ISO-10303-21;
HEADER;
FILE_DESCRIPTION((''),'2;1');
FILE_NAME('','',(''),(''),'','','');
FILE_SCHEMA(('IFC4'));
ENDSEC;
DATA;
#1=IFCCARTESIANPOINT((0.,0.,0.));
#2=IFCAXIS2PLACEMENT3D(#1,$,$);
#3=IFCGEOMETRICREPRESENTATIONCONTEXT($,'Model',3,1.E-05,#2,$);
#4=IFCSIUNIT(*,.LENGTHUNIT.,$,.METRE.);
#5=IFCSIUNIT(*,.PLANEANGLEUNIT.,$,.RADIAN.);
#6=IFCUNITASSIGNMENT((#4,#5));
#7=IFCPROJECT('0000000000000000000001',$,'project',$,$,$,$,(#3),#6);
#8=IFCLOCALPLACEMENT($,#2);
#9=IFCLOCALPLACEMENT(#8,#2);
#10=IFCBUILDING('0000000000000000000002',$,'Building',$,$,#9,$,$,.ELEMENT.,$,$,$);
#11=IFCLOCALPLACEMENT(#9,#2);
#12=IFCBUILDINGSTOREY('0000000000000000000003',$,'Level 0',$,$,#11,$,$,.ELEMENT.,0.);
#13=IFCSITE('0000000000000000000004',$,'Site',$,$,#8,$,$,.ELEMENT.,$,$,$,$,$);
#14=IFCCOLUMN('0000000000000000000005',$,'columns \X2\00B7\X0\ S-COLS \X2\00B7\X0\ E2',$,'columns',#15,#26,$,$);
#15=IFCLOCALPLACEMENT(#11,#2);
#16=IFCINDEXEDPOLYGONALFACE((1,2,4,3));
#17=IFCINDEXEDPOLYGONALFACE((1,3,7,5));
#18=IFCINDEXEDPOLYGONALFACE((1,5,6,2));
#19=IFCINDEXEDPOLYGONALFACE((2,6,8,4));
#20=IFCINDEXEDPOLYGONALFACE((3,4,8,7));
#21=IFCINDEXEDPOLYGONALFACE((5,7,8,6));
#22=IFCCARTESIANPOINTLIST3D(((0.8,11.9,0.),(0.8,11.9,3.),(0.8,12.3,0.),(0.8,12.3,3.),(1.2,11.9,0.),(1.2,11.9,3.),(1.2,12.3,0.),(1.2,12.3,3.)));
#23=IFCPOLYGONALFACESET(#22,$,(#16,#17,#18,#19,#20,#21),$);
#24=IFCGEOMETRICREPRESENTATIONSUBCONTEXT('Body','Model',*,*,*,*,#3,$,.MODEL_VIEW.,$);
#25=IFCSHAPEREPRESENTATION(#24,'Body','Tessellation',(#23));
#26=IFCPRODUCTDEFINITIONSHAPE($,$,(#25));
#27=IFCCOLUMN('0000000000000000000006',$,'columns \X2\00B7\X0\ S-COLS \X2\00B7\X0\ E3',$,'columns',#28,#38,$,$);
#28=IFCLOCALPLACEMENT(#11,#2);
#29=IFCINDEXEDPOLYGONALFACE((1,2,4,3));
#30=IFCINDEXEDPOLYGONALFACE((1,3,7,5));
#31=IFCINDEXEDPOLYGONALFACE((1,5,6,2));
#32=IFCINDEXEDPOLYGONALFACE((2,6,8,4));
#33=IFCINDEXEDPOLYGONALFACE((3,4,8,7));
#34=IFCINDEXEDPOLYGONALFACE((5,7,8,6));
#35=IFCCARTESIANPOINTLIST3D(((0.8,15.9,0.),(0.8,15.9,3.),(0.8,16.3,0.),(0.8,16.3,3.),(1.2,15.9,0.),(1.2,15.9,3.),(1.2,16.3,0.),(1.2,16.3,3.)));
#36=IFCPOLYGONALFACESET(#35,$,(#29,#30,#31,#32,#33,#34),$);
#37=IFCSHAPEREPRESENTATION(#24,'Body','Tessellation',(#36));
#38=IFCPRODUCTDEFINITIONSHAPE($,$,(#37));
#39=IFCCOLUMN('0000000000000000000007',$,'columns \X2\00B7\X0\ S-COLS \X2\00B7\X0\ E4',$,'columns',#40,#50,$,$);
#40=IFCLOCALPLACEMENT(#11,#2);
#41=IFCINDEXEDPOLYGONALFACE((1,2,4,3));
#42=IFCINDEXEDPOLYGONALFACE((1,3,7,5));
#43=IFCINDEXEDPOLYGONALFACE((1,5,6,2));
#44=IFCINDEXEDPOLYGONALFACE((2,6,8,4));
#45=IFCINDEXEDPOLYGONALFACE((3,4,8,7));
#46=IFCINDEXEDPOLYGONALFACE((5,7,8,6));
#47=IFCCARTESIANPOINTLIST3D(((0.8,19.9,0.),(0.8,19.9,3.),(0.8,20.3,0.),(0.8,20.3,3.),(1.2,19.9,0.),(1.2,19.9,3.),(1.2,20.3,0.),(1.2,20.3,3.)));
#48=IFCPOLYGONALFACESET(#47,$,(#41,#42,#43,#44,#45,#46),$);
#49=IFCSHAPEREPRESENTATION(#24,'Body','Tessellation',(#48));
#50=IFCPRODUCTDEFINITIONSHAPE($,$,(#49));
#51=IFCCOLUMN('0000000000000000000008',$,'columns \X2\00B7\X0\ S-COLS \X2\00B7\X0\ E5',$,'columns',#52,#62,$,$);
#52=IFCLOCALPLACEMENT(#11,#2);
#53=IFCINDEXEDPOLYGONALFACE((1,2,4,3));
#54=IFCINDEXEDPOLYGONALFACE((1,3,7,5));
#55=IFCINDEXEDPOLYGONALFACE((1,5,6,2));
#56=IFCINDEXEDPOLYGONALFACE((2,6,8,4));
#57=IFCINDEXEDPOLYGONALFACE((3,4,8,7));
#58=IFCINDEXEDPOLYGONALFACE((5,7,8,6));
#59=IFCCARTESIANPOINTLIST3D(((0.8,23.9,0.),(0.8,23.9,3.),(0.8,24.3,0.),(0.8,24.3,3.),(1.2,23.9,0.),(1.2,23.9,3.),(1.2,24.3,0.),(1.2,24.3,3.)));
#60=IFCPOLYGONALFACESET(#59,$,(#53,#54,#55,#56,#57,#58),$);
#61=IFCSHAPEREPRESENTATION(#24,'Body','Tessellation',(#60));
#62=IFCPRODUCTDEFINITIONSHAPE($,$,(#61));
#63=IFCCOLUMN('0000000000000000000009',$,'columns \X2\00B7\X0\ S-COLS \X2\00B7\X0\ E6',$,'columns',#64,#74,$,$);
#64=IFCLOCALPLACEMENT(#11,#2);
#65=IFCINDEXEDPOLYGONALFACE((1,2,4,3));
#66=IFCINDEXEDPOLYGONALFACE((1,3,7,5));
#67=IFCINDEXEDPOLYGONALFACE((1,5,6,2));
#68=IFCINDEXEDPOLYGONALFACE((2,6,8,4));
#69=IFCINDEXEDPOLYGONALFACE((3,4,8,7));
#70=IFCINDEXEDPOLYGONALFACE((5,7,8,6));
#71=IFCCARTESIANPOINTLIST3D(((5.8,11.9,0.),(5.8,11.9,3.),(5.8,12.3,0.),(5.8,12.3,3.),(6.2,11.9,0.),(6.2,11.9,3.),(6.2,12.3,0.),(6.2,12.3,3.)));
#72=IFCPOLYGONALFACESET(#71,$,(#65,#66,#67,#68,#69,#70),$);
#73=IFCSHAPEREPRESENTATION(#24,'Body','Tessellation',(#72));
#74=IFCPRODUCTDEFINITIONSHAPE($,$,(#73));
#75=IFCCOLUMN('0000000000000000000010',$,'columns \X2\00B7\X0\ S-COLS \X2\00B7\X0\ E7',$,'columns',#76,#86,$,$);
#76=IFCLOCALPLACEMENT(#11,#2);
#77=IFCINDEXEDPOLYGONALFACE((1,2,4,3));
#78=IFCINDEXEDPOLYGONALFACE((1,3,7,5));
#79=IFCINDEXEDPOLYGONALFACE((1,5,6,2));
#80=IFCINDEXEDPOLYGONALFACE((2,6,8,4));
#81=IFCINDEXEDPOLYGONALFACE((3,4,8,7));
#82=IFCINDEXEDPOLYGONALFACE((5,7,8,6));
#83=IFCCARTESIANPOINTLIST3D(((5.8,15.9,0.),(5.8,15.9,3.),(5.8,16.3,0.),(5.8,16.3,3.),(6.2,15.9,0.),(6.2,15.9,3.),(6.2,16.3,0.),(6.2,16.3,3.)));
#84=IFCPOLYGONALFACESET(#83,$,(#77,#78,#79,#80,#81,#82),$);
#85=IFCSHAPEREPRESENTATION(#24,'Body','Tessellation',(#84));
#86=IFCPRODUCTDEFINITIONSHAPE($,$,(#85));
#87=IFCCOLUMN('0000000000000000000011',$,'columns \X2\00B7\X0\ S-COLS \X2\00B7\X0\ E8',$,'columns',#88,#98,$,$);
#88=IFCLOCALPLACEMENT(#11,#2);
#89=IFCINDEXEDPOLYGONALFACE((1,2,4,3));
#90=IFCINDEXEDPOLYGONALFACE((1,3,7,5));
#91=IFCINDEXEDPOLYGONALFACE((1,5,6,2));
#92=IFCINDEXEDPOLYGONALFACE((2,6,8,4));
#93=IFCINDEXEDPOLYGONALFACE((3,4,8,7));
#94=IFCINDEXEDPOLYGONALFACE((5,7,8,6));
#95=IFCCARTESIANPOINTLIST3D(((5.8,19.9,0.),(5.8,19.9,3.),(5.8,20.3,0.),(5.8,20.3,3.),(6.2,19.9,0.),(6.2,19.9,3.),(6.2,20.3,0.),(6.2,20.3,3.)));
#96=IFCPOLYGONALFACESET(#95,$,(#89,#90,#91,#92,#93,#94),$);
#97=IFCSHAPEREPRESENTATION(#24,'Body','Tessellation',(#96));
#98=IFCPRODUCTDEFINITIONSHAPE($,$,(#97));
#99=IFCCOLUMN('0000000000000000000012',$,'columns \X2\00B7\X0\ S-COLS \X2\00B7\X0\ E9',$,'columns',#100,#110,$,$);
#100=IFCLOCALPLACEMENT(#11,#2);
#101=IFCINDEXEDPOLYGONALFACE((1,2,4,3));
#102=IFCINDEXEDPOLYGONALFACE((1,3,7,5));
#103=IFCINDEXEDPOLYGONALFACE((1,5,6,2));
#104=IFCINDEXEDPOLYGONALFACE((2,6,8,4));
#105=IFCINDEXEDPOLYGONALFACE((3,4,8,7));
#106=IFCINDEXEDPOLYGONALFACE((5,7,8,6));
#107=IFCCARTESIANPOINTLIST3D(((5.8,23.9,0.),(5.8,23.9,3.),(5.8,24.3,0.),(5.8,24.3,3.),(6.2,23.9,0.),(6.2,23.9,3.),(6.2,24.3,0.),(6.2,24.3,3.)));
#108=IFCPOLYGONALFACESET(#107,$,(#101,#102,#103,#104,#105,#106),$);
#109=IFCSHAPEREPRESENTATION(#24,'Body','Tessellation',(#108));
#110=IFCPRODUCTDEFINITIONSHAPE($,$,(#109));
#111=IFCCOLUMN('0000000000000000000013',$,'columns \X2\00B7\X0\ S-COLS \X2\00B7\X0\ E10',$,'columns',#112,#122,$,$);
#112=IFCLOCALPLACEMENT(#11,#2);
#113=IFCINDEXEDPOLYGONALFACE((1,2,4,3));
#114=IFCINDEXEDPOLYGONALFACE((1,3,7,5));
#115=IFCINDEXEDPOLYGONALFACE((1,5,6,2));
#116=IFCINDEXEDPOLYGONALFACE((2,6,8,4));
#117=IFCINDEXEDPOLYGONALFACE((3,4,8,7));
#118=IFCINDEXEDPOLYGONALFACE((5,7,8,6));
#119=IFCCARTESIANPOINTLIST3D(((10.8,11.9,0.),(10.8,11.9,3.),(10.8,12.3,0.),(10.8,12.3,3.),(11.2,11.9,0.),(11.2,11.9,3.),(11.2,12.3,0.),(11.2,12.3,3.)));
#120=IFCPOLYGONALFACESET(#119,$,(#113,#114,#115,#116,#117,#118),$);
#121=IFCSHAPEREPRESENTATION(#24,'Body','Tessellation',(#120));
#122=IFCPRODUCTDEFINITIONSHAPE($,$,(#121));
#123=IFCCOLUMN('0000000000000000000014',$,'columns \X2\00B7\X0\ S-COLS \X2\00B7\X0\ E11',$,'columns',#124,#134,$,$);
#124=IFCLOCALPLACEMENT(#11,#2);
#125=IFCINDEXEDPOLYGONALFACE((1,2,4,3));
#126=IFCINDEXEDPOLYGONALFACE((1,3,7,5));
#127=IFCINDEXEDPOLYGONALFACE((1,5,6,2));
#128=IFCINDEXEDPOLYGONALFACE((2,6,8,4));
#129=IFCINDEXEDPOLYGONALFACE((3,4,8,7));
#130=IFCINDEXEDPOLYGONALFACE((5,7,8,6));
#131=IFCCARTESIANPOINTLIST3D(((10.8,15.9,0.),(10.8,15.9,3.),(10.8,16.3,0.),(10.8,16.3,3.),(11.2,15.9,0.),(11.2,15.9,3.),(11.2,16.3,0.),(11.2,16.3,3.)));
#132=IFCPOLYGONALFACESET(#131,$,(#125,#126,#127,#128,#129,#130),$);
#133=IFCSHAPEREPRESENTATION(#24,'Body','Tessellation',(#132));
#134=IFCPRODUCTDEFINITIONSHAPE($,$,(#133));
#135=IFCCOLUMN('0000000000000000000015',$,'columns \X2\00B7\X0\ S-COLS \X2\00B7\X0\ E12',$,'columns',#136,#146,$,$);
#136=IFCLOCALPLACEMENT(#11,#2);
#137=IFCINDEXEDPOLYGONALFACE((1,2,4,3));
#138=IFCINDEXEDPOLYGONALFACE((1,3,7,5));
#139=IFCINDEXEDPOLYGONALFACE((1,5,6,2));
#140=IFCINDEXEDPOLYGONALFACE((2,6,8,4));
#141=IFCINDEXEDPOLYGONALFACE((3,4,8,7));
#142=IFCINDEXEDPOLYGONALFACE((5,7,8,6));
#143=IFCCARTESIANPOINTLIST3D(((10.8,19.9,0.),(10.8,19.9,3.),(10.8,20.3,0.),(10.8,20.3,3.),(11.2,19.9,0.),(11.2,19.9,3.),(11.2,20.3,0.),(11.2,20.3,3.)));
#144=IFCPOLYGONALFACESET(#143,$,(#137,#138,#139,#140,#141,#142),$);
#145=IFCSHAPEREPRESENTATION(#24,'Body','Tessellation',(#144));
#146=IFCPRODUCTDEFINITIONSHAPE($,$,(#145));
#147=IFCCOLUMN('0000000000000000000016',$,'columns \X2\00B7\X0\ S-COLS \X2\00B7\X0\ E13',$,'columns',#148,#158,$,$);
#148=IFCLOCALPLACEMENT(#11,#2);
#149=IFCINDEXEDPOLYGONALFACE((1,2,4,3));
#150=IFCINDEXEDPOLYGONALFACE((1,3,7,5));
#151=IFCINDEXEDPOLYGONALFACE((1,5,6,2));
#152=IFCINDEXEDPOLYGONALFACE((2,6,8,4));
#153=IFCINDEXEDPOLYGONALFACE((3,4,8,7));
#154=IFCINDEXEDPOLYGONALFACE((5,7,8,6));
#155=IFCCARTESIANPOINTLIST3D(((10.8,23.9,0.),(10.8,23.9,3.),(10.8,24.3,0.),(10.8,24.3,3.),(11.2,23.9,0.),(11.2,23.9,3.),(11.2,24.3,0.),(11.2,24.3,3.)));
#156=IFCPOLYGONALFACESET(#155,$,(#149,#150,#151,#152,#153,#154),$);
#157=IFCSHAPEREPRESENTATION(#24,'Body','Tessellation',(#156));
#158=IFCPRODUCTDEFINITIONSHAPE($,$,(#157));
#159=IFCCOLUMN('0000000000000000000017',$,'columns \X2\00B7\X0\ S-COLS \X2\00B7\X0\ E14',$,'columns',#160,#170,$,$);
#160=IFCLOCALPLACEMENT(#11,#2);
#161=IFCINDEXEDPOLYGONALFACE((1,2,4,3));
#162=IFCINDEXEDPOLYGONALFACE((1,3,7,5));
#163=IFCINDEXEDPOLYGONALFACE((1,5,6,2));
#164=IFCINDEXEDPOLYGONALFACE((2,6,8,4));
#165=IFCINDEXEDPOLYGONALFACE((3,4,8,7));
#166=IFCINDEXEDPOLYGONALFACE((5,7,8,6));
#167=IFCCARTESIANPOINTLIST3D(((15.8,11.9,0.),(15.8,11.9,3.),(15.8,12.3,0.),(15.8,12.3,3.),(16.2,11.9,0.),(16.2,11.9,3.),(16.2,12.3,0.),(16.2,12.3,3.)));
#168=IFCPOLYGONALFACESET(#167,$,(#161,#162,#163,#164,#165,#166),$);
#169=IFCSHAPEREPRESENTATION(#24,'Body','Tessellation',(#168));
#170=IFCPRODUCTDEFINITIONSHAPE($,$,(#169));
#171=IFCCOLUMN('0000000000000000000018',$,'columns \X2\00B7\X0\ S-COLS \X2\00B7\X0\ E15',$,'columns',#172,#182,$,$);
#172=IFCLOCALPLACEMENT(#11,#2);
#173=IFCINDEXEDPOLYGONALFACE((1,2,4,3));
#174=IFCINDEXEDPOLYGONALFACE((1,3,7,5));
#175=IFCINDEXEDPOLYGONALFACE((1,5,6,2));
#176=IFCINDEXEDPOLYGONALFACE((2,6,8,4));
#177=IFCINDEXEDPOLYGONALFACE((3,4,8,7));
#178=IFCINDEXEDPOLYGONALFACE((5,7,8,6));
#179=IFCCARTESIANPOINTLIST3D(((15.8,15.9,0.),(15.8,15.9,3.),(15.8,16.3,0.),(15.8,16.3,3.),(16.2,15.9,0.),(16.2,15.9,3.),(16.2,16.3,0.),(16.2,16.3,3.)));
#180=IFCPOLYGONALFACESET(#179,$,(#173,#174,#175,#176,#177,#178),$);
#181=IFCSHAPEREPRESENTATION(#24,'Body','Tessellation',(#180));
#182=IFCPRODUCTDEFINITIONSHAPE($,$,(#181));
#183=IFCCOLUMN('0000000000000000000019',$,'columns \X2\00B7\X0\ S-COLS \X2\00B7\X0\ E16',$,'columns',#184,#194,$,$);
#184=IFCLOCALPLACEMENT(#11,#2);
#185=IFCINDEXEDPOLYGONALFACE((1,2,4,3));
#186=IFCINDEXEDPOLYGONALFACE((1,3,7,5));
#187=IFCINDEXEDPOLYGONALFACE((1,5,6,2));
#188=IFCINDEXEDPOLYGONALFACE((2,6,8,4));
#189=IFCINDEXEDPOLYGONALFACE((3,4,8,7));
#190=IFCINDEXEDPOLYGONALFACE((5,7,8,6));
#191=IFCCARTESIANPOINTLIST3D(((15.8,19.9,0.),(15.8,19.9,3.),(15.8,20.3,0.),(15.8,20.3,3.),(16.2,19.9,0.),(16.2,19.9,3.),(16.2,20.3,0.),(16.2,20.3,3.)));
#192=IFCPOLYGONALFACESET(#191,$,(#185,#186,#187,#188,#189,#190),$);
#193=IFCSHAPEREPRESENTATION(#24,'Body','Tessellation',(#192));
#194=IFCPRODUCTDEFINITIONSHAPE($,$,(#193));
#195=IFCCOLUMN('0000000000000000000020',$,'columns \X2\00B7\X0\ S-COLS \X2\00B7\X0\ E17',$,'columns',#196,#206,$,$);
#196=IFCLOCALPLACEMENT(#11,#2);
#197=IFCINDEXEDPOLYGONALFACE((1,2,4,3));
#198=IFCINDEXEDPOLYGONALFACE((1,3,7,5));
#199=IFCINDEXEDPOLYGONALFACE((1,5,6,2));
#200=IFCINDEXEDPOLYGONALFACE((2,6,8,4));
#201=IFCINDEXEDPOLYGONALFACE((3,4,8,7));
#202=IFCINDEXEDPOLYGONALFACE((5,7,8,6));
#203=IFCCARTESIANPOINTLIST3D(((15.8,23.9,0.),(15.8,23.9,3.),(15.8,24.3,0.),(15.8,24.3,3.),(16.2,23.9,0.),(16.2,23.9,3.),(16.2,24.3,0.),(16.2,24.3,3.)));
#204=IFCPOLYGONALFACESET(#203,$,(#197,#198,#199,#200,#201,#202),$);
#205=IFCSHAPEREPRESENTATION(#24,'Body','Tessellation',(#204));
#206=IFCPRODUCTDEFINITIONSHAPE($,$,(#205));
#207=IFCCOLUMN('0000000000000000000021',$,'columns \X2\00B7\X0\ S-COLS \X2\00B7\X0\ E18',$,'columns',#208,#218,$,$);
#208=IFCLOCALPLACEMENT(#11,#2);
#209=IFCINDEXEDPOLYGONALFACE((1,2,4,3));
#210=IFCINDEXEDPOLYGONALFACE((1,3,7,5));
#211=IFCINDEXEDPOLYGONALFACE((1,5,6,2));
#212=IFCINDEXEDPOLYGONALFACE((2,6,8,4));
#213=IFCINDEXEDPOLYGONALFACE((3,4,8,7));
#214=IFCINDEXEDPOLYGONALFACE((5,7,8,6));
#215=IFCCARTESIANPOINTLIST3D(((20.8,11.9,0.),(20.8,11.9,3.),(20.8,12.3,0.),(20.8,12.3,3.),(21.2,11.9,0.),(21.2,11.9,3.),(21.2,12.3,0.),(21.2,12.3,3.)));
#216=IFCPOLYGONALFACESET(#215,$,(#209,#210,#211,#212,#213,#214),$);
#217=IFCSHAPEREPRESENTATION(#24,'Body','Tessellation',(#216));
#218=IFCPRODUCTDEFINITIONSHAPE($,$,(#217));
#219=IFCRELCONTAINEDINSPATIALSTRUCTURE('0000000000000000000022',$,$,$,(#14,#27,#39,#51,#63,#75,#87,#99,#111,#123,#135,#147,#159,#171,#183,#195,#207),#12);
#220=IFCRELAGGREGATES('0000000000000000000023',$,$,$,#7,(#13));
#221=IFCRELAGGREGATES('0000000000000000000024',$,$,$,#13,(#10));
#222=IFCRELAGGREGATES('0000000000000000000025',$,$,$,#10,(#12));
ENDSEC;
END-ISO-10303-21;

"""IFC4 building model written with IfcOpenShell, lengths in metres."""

from ifc_helpers import new_model, si_unit, origin, place, context, subcontext, project, spatial, polyline, outline, extrude, element, save


model = new_model("IFC4")

# Units and contexts
model_context = context("Model", 3, precision=1e-05, world=origin())
body_context = subcontext(model_context, "Body", "Model", "MODEL_VIEW")
ifc_project = project(units=[si_unit("LENGTHUNIT", "METRE"), si_unit("PLANEANGLEUNIT", "RADIAN")], contexts=[model_context])

# Site, building, storey
site_placement = place(None, origin())
site = spatial("IfcSite", under=ifc_project, at=site_placement, Name="Site", CompositionType="ELEMENT")
building_placement = place(site_placement, origin())
building = spatial("IfcBuilding", under=site, at=building_placement, Name="Building", CompositionType="ELEMENT")
storey_placement = place(building_placement, origin())
storey = spatial("IfcBuildingStorey", under=building, at=storey_placement, Name="Level 0", CompositionType="ELEMENT", Elevation=0.0)

# Columns
column_1_placement = place(storey_placement, origin())
element("IfcColumn", 1, at=column_1_placement, inside=storey, Name="columns · S-COLS · E2", ObjectType="columns", context=body_context, shape_type="SweptSolid", body=[
    extrude(outline(polyline([(0.8, 11.9), (1.2, 11.9), (1.2, 12.3), (0.8, 12.3), (0.8, 11.9)])), origin(), (0.0, 0.0, 1.0), 3.0),
])
column_2_placement = place(storey_placement, origin())
element("IfcColumn", 2, at=column_2_placement, inside=storey, Name="columns · S-COLS · E3", ObjectType="columns", context=body_context, shape_type="SweptSolid", body=[
    extrude(outline(polyline([(0.8, 15.9), (1.2, 15.9), (1.2, 16.3), (0.8, 16.3), (0.8, 15.9)])), origin(), (0.0, 0.0, 1.0), 3.0),
])
column_3_placement = place(storey_placement, origin())
element("IfcColumn", 3, at=column_3_placement, inside=storey, Name="columns · S-COLS · E4", ObjectType="columns", context=body_context, shape_type="SweptSolid", body=[
    extrude(outline(polyline([(0.8, 19.9), (1.2, 19.9), (1.2, 20.3), (0.8, 20.3), (0.8, 19.9)])), origin(), (0.0, 0.0, 1.0), 3.0),
])
column_4_placement = place(storey_placement, origin())
element("IfcColumn", 4, at=column_4_placement, inside=storey, Name="columns · S-COLS · E5", ObjectType="columns", context=body_context, shape_type="SweptSolid", body=[
    extrude(outline(polyline([(0.8, 23.9), (1.2, 23.9), (1.2, 24.3), (0.8, 24.3), (0.8, 23.9)])), origin(), (0.0, 0.0, 1.0), 3.0),
])
column_5_placement = place(storey_placement, origin())
element("IfcColumn", 5, at=column_5_placement, inside=storey, Name="columns · S-COLS · E6", ObjectType="columns", context=body_context, shape_type="SweptSolid", body=[
    extrude(outline(polyline([(5.8, 11.9), (6.2, 11.9), (6.2, 12.3), (5.8, 12.3), (5.8, 11.9)])), origin(), (0.0, 0.0, 1.0), 3.0),
])
column_6_placement = place(storey_placement, origin())
element("IfcColumn", 6, at=column_6_placement, inside=storey, Name="columns · S-COLS · E7", ObjectType="columns", context=body_context, shape_type="SweptSolid", body=[
    extrude(outline(polyline([(5.8, 15.9), (6.2, 15.9), (6.2, 16.3), (5.8, 16.3), (5.8, 15.9)])), origin(), (0.0, 0.0, 1.0), 3.0),
])
column_7_placement = place(storey_placement, origin())
element("IfcColumn", 7, at=column_7_placement, inside=storey, Name="columns · S-COLS · E8", ObjectType="columns", context=body_context, shape_type="SweptSolid", body=[
    extrude(outline(polyline([(5.8, 19.9), (6.2, 19.9), (6.2, 20.3), (5.8, 20.3), (5.8, 19.9)])), origin(), (0.0, 0.0, 1.0), 3.0),
])
column_8_placement = place(storey_placement, origin())
element("IfcColumn", 8, at=column_8_placement, inside=storey, Name="columns · S-COLS · E9", ObjectType="columns", context=body_context, shape_type="SweptSolid", body=[
    extrude(outline(polyline([(5.8, 23.9), (6.2, 23.9), (6.2, 24.3), (5.8, 24.3), (5.8, 23.9)])), origin(), (0.0, 0.0, 1.0), 3.0),
])
column_9_placement = place(storey_placement, origin())
element("IfcColumn", 9, at=column_9_placement, inside=storey, Name="columns · S-COLS · E10", ObjectType="columns", context=body_context, shape_type="SweptSolid", body=[
    extrude(outline(polyline([(10.8, 11.9), (11.2, 11.9), (11.2, 12.3), (10.8, 12.3), (10.8, 11.9)])), origin(), (0.0, 0.0, 1.0), 3.0),
])
column_10_placement = place(storey_placement, origin())
element("IfcColumn", 10, at=column_10_placement, inside=storey, Name="columns · S-COLS · E11", ObjectType="columns", context=body_context, shape_type="SweptSolid", body=[
    extrude(outline(polyline([(10.8, 15.9), (11.2, 15.9), (11.2, 16.3), (10.8, 16.3), (10.8, 15.9)])), origin(), (0.0, 0.0, 1.0), 3.0),
])
column_11_placement = place(storey_placement, origin())
element("IfcColumn", 11, at=column_11_placement, inside=storey, Name="columns · S-COLS · E12", ObjectType="columns", context=body_context, shape_type="SweptSolid", body=[
    extrude(outline(polyline([(10.8, 19.9), (11.2, 19.9), (11.2, 20.3), (10.8, 20.3), (10.8, 19.9)])), origin(), (0.0, 0.0, 1.0), 3.0),
])
column_12_placement = place(storey_placement, origin())
element("IfcColumn", 12, at=column_12_placement, inside=storey, Name="columns · S-COLS · E13", ObjectType="columns", context=body_context, shape_type="SweptSolid", body=[
    extrude(outline(polyline([(10.8, 23.9), (11.2, 23.9), (11.2, 24.3), (10.8, 24.3), (10.8, 23.9)])), origin(), (0.0, 0.0, 1.0), 3.0),
])
column_13_placement = place(storey_placement, origin())
element("IfcColumn", 13, at=column_13_placement, inside=storey, Name="columns · S-COLS · E14", ObjectType="columns", context=body_context, shape_type="SweptSolid", body=[
    extrude(outline(polyline([(15.8, 11.9), (16.2, 11.9), (16.2, 12.3), (15.8, 12.3), (15.8, 11.9)])), origin(), (0.0, 0.0, 1.0), 3.0),
])
column_14_placement = place(storey_placement, origin())
element("IfcColumn", 14, at=column_14_placement, inside=storey, Name="columns · S-COLS · E15", ObjectType="columns", context=body_context, shape_type="SweptSolid", body=[
    extrude(outline(polyline([(15.8, 15.9), (16.2, 15.9), (16.2, 16.3), (15.8, 16.3), (15.8, 15.9)])), origin(), (0.0, 0.0, 1.0), 3.0),
])
column_15_placement = place(storey_placement, origin())
element("IfcColumn", 15, at=column_15_placement, inside=storey, Name="columns · S-COLS · E16", ObjectType="columns", context=body_context, shape_type="SweptSolid", body=[
    extrude(outline(polyline([(15.8, 19.9), (16.2, 19.9), (16.2, 20.3), (15.8, 20.3), (15.8, 19.9)])), origin(), (0.0, 0.0, 1.0), 3.0),
])
column_16_placement = place(storey_placement, origin())
element("IfcColumn", 16, at=column_16_placement, inside=storey, Name="columns · S-COLS · E17", ObjectType="columns", context=body_context, shape_type="SweptSolid", body=[
    extrude(outline(polyline([(15.8, 23.9), (16.2, 23.9), (16.2, 24.3), (15.8, 24.3), (15.8, 23.9)])), origin(), (0.0, 0.0, 1.0), 3.0),
])
column_17_placement = place(storey_placement, origin())
element("IfcColumn", 17, at=column_17_placement, inside=storey, Name="columns · S-COLS · E18", ObjectType="columns", context=body_context, shape_type="SweptSolid", body=[
    extrude(outline(polyline([(20.8, 11.9), (21.2, 11.9), (21.2, 12.3), (20.8, 12.3), (20.8, 11.9)])), origin(), (0.0, 0.0, 1.0), 3.0),
])

save(model, "model.ifc")
